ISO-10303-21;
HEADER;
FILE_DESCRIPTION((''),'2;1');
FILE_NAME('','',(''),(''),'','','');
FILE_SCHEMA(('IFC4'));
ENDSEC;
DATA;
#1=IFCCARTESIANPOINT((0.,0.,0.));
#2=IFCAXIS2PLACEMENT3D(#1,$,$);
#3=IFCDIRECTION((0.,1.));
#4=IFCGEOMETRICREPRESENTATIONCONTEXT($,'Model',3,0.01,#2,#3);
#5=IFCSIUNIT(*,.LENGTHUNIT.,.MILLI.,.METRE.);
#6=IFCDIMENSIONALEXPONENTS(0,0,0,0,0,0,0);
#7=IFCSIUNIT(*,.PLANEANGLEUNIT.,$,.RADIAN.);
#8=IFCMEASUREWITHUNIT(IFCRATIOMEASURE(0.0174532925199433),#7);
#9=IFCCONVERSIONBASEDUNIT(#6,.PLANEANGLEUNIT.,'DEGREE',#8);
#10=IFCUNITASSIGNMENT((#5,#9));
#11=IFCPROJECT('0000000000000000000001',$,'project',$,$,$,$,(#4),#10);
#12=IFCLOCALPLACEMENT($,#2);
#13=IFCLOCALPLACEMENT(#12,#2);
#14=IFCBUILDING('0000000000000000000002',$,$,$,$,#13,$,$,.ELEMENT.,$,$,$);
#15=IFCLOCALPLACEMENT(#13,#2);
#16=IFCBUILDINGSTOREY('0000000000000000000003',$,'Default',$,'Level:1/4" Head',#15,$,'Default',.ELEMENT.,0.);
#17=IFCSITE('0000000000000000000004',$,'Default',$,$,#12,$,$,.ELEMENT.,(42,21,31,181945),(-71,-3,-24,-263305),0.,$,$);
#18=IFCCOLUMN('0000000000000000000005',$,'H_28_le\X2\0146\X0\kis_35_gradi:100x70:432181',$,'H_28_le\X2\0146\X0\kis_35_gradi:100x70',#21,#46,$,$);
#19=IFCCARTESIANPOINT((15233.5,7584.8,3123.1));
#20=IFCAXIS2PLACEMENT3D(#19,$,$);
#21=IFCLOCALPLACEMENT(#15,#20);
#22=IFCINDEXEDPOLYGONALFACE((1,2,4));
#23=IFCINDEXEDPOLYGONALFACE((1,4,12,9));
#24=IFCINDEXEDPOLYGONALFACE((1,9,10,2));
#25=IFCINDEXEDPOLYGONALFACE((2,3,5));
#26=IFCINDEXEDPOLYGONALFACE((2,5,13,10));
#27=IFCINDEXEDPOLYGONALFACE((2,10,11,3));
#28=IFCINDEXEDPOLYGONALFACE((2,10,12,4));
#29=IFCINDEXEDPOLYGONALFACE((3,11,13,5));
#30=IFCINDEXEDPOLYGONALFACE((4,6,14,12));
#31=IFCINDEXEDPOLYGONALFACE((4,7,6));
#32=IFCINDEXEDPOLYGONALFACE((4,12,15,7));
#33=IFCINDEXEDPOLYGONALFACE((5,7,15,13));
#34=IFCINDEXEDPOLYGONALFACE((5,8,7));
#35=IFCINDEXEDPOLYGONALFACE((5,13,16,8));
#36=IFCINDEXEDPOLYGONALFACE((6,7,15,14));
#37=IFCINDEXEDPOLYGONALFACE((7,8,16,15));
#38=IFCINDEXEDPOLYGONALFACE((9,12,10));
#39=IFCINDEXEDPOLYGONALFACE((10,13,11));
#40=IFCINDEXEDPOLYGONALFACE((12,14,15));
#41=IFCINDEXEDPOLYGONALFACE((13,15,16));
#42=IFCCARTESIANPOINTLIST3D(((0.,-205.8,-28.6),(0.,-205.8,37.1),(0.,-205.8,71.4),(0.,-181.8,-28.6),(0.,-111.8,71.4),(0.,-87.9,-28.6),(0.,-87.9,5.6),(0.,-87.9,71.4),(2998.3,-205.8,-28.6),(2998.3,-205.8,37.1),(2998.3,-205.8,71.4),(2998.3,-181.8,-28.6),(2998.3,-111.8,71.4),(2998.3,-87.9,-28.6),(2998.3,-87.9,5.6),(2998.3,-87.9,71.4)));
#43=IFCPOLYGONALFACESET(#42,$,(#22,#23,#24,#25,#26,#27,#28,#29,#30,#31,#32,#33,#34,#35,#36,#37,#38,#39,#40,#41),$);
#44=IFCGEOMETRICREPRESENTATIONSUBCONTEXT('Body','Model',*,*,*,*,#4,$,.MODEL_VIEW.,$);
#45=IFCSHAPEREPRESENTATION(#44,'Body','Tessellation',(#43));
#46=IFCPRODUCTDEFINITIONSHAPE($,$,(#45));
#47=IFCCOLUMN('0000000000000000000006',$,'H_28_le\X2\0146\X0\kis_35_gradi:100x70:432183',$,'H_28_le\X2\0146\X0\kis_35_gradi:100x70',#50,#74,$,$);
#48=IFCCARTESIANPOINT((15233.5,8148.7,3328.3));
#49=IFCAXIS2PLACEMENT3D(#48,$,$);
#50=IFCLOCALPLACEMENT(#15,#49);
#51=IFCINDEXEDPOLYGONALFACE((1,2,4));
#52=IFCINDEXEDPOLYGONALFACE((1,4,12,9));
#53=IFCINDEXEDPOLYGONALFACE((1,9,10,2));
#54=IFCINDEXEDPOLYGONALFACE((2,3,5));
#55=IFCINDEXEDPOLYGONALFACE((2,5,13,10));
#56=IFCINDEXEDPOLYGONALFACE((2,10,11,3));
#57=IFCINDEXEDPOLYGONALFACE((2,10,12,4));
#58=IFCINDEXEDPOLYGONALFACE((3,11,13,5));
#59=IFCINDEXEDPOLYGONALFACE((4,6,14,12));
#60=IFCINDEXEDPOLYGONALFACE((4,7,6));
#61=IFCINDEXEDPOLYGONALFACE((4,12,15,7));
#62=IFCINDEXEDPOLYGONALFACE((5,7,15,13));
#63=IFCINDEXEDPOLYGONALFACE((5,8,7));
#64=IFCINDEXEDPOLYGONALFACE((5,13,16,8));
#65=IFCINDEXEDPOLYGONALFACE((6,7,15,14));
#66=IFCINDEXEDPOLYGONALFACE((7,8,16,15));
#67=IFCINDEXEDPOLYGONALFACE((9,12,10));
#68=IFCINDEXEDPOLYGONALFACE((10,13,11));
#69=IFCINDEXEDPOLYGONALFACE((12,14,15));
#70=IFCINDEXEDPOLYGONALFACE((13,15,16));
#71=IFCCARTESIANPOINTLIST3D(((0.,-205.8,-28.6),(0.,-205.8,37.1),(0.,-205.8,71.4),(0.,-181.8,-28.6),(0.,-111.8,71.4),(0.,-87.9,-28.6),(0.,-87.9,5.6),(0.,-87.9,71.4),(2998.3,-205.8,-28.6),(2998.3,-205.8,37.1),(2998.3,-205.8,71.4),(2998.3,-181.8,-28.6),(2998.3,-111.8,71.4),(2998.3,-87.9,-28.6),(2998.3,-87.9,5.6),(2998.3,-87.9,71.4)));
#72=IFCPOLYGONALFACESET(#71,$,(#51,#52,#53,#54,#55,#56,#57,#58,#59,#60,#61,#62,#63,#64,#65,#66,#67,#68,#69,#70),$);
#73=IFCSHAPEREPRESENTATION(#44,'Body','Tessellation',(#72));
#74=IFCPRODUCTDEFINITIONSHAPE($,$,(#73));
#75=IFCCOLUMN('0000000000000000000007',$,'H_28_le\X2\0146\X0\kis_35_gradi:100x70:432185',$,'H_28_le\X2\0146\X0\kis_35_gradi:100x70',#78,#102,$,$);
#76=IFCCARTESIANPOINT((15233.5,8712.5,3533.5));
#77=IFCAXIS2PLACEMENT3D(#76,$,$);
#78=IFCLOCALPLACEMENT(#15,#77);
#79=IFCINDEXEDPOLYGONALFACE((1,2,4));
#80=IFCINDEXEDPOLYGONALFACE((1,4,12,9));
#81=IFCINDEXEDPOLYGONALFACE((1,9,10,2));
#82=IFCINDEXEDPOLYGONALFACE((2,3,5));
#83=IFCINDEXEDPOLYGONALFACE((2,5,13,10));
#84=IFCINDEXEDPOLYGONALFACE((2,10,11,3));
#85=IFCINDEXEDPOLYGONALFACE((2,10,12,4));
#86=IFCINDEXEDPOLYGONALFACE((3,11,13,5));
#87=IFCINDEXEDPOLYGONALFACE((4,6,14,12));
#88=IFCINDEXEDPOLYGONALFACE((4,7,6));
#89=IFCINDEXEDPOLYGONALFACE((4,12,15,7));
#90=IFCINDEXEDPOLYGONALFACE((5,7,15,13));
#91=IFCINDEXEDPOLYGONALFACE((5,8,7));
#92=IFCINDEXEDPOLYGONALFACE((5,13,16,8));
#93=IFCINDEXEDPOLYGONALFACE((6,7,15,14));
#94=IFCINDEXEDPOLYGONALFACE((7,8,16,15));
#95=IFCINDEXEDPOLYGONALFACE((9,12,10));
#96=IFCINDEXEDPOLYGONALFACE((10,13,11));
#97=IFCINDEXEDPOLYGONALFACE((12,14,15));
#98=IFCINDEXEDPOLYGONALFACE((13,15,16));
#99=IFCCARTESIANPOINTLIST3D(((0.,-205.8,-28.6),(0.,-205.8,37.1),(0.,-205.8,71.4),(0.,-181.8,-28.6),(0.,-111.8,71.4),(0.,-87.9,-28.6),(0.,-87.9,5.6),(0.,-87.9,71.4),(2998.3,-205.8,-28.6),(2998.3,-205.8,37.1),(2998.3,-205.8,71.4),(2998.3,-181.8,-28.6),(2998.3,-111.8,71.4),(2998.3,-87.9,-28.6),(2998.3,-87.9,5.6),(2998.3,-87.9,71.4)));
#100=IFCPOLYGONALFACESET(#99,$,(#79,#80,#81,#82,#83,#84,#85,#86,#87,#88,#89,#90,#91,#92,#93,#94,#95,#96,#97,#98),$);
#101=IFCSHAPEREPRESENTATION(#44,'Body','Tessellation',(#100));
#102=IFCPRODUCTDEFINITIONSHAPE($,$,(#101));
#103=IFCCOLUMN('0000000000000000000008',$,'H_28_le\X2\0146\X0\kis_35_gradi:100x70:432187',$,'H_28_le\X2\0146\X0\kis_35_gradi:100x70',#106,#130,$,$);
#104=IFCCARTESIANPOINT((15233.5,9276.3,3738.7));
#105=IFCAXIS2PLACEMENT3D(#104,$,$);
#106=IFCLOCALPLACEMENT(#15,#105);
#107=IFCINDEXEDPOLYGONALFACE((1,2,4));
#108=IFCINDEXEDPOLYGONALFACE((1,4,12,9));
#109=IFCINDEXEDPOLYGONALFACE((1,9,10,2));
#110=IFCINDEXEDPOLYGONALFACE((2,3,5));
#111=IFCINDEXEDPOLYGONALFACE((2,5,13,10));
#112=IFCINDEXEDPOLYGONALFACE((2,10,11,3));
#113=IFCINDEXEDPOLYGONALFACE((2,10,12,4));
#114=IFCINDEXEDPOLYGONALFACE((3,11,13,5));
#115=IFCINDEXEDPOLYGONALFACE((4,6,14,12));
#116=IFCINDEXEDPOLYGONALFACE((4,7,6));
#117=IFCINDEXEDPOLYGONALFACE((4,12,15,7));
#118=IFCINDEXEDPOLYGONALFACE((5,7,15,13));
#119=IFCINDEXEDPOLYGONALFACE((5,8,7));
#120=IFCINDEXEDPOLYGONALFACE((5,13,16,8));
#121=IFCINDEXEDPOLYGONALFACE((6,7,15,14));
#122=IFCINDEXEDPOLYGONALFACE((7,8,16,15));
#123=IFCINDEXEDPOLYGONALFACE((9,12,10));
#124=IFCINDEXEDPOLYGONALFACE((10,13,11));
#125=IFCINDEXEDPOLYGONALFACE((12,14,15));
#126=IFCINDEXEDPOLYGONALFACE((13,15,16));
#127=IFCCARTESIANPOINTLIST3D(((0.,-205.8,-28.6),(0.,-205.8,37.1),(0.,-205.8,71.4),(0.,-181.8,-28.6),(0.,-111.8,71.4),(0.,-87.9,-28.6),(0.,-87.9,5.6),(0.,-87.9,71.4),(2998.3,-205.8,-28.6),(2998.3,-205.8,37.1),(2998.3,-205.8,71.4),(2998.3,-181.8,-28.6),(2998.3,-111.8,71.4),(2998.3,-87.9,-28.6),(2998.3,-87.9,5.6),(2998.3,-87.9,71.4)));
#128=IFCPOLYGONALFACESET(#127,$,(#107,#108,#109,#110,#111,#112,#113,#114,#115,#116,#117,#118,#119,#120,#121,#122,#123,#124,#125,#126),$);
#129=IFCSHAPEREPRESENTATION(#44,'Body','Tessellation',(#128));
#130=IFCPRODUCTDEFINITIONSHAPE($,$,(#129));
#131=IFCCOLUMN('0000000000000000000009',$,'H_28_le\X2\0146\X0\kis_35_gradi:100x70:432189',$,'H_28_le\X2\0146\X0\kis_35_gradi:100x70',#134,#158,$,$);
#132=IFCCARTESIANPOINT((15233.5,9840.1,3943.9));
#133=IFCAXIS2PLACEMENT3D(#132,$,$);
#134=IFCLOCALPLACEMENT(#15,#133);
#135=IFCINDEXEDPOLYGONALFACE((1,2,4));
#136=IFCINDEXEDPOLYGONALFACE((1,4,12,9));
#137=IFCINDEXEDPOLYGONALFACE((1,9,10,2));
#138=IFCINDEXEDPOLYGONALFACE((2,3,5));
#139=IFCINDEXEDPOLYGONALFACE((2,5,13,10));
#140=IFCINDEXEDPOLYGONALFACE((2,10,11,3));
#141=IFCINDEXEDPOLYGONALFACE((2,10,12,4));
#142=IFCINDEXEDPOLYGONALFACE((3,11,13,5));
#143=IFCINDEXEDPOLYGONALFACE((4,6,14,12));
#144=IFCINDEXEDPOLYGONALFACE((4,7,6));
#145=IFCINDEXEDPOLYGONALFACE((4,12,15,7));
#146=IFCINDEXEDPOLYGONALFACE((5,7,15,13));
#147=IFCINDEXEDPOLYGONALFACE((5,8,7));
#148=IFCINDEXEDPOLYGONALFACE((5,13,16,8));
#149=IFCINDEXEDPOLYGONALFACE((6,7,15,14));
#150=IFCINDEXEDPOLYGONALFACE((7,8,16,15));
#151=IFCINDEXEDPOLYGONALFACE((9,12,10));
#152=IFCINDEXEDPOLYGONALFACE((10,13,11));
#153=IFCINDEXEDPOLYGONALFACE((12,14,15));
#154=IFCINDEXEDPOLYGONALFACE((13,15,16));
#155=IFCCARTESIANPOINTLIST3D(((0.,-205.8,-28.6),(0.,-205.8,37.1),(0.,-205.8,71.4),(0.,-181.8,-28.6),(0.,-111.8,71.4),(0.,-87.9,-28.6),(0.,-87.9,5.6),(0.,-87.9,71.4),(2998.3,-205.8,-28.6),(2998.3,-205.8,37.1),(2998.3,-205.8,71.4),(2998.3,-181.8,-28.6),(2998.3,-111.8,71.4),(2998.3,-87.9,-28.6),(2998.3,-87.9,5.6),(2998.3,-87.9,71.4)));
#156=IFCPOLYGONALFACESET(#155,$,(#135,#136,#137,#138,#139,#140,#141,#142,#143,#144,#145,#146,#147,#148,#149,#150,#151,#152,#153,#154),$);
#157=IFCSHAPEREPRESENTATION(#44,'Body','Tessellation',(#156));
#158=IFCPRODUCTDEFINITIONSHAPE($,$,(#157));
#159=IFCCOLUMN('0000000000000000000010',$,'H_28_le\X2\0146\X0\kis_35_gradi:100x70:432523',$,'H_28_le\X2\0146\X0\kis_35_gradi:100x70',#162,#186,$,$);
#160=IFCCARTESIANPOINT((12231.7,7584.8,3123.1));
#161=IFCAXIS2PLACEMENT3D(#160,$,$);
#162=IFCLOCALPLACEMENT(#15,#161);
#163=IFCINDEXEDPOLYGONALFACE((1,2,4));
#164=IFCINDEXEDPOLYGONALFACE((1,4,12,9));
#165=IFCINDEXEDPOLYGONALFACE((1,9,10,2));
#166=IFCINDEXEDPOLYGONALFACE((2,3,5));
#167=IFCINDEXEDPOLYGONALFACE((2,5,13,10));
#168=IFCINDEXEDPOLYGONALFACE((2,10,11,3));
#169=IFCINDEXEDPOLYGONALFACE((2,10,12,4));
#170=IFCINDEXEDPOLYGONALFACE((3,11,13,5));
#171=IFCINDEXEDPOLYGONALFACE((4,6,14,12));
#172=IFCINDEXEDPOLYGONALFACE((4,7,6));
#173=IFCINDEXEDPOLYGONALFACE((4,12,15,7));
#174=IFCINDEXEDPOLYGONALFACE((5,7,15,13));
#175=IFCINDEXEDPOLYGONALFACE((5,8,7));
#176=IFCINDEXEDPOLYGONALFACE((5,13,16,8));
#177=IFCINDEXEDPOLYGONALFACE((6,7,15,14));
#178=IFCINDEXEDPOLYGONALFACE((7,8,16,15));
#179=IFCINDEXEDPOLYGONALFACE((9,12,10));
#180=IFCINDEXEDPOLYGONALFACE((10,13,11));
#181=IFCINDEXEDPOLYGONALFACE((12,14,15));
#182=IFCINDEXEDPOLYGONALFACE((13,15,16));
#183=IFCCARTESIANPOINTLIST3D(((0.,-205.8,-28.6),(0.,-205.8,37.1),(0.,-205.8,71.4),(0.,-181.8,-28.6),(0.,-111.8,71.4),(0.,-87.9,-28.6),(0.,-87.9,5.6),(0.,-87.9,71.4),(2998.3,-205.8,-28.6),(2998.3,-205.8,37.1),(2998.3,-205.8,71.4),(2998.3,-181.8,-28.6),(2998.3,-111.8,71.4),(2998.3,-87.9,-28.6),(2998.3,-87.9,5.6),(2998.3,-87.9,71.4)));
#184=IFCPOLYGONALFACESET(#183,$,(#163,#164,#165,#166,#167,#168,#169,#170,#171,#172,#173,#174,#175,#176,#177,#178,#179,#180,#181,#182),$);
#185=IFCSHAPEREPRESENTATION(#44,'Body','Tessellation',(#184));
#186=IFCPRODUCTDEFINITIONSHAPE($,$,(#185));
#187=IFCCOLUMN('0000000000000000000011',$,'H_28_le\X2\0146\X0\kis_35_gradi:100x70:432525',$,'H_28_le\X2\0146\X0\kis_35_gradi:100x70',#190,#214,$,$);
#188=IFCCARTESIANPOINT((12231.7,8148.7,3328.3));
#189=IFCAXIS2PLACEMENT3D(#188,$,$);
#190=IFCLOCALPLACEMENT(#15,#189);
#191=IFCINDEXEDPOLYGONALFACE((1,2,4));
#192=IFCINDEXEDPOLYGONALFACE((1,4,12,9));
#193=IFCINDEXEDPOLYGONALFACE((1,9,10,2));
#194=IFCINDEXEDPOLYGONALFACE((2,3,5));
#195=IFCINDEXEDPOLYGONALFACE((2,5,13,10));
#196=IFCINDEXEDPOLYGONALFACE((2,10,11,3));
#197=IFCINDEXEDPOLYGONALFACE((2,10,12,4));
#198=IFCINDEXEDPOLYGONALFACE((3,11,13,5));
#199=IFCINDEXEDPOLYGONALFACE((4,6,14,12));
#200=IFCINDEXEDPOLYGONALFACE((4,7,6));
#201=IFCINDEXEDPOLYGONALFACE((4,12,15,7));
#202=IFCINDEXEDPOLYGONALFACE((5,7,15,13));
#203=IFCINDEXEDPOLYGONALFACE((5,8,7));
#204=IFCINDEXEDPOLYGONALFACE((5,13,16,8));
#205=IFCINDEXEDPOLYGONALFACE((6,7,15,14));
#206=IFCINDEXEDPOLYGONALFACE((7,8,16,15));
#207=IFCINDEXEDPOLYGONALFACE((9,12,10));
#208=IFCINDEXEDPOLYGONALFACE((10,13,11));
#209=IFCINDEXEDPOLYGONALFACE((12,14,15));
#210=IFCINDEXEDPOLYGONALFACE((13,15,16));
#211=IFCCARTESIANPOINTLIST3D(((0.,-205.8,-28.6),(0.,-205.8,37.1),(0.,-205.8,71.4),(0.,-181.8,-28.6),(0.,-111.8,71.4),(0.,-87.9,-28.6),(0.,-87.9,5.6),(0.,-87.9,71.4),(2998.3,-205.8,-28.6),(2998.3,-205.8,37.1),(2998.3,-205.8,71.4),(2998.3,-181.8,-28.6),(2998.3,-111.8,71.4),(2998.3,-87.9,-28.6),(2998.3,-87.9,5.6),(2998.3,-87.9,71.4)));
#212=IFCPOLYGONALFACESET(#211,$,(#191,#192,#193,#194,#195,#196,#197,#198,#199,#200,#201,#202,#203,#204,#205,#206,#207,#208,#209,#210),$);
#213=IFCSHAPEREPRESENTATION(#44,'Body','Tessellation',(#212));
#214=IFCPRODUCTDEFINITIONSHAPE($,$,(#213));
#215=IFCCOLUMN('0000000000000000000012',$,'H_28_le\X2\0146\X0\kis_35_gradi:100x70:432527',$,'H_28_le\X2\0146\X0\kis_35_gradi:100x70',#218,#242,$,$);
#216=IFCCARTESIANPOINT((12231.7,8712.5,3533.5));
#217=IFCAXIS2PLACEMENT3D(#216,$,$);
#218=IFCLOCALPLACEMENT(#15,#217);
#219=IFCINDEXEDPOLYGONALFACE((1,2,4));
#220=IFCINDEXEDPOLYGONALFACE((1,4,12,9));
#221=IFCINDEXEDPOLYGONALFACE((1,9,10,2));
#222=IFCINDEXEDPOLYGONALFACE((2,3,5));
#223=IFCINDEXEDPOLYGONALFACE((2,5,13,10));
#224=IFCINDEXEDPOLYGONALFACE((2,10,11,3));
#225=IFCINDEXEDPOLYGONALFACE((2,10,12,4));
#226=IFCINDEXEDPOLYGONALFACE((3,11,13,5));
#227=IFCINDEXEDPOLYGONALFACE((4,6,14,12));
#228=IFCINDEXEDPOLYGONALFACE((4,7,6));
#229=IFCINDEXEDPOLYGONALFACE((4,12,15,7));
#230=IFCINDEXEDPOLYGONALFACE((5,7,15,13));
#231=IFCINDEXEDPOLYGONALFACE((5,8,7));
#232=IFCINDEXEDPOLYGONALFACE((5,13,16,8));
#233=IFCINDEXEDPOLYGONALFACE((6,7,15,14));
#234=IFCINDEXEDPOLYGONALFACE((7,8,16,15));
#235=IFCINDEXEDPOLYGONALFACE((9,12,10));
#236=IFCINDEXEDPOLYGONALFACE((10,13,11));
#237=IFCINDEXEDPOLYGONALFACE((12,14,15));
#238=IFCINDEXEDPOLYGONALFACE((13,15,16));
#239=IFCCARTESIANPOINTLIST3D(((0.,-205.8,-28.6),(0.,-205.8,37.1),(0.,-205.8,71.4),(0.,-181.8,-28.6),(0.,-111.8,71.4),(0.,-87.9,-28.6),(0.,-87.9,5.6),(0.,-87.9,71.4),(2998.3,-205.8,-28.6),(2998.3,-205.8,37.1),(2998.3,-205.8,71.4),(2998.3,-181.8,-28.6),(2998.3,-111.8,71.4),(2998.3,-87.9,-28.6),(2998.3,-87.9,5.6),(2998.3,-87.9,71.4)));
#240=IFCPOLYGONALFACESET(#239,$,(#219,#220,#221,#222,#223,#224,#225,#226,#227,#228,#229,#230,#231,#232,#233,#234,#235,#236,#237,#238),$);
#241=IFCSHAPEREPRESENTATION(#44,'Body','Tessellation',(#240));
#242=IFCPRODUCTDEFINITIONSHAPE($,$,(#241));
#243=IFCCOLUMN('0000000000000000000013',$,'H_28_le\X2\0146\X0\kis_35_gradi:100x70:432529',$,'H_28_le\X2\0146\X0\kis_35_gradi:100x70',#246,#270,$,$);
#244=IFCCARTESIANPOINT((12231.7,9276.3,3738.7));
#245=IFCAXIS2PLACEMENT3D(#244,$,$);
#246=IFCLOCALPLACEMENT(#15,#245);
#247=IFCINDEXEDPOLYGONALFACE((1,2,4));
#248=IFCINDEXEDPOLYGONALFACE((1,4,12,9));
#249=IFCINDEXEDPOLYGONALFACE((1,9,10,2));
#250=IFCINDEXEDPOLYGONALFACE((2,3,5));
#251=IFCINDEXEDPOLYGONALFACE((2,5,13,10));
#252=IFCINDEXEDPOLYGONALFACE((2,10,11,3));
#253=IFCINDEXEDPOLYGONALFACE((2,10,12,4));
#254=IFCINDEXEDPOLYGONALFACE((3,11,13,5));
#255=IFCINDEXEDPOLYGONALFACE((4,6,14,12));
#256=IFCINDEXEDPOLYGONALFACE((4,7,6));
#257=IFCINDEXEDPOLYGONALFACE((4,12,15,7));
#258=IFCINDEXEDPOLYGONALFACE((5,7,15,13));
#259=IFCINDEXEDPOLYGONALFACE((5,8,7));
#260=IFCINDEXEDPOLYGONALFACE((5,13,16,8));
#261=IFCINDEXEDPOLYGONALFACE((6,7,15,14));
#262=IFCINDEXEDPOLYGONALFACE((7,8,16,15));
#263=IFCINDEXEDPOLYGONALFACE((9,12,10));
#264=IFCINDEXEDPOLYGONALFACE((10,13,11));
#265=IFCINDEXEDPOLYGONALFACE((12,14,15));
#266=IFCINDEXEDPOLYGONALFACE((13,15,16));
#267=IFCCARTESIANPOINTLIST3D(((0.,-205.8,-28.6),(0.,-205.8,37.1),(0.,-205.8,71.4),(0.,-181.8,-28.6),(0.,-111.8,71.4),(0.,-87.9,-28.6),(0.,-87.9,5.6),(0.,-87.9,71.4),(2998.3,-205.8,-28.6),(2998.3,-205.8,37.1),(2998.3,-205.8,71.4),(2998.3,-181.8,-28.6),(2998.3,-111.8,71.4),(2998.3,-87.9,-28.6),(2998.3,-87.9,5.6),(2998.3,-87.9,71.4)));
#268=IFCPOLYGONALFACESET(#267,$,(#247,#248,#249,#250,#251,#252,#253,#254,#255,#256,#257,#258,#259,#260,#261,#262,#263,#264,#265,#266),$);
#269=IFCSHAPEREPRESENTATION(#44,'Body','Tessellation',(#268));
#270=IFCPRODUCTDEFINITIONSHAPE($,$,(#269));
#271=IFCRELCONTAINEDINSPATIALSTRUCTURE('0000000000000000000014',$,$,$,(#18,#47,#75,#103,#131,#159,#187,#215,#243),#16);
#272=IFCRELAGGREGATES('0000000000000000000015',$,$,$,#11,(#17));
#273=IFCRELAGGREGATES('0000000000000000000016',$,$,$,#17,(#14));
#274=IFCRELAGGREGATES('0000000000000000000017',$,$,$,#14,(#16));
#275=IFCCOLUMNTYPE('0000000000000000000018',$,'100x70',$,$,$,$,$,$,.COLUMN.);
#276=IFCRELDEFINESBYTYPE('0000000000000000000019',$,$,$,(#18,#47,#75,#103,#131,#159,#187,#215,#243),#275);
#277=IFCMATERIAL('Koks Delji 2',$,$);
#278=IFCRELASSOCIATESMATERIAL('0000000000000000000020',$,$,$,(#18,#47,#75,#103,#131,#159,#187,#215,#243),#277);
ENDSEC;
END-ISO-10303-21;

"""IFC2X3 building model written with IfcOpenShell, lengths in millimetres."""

from ifc_helpers import new_model, entity, si_unit, converted_unit, direction, frame, frame_2d, origin, place, context, subcontext, project, spatial, rectangle, extrude, boolean, source, transform, mapped, material, type_object, type_shapes, element, save


model = new_model("IFC2X3")

# Units and contexts
model_context = context("Model", 3, precision=0.01, world=origin(), true_north=direction((0.0, 1.0)))
body_context = subcontext(model_context, "Body", "Model", "MODEL_VIEW")
ifc_project = project(units=[si_unit("LENGTHUNIT", "METRE", prefix="MILLI"), converted_unit("PLANEANGLEUNIT", "DEGREE", entity("IfcRatioMeasure", 0.0174532925199433), si_unit("PLANEANGLEUNIT", "RADIAN"), dimensions=[0, 0, 0, 0, 0, 0, 0])], contexts=[model_context])

# Site, building, storey
site_placement = place(None, origin())
site = spatial("IfcSite", under=ifc_project, at=site_placement, Name="Default", CompositionType="ELEMENT", RefLatitude=(42, 21, 31, 181945), RefLongitude=(-71, -3, -24, -263305), RefElevation=0.0)
building_placement = place(site_placement, origin())
building = spatial("IfcBuilding", under=site, at=building_placement, CompositionType="ELEMENT")
storey_placement = place(building_placement, origin())
storey = spatial("IfcBuildingStorey", under=building, at=storey_placement, Name="Default", ObjectType="Level:1/4\" Head", LongName="Default", CompositionType="ELEMENT", Elevation=0.0)

# Columns
ifc_material_1 = material(Name="Koks Delji 2")
column_type = type_object("IfcColumnType", Name="100x70", PredefinedType="COLUMN")
shared_shape_1 = source(origin(), body_context, "Body", "CSG", [
    boolean("DIFFERENCE", extrude(rectangle(XDim=2998.3, YDim=117.9, at=frame_2d((0.0, 0.0), x_axis=(1.0, 0.0))), frame((1499.1, -146.8, -28.6)), (0.0, 0.0, 1.0), 100.0), extrude(rectangle(XDim=70.0, YDim=100.0, at=frame_2d((0.0, 0.0), x_axis=(0.0, 1.0))), frame((0.0, -146.8, 21.4), z_axis=(-1.0, 0.0, 0.0), x_axis=(0.0, -0.939693, -0.34202)), (0.0, 0.0, -1.0), 2998.3)),
])
type_shapes(column_type, [shared_shape_1])
for number, where, name in (
    (1, (15233.5, 7584.8, 3123.1), "H_28_leņkis_35_gradi:100x70:432181"),
    (2, (15233.5, 8148.7, 3328.3), "H_28_leņkis_35_gradi:100x70:432183"),
    (3, (15233.5, 8712.5, 3533.5), "H_28_leņkis_35_gradi:100x70:432185"),
    (4, (15233.5, 9276.3, 3738.7), "H_28_leņkis_35_gradi:100x70:432187"),
    (5, (15233.5, 9840.1, 3943.9), "H_28_leņkis_35_gradi:100x70:432189"),
    (6, (12231.7, 7584.8, 3123.1), "H_28_leņkis_35_gradi:100x70:432523"),
    (7, (12231.7, 8148.7, 3328.3), "H_28_leņkis_35_gradi:100x70:432525"),
    (8, (12231.7, 8712.5, 3533.5), "H_28_leņkis_35_gradi:100x70:432527"),
    (9, (12231.7, 9276.3, 3738.7), "H_28_leņkis_35_gradi:100x70:432529"),
):
    element("IfcColumn", number, at=place(storey_placement, frame(where)), inside=storey, type_object=column_type, material=ifc_material_1, Name=name, ObjectType="H_28_leņkis_35_gradi:100x70", context=body_context, shape_type="MappedRepresentation", body=[
        mapped(shared_shape_1, transform((0.0, 0.0, 0.0), scale=1.0)),
    ])

save(model, "model.ifc")
